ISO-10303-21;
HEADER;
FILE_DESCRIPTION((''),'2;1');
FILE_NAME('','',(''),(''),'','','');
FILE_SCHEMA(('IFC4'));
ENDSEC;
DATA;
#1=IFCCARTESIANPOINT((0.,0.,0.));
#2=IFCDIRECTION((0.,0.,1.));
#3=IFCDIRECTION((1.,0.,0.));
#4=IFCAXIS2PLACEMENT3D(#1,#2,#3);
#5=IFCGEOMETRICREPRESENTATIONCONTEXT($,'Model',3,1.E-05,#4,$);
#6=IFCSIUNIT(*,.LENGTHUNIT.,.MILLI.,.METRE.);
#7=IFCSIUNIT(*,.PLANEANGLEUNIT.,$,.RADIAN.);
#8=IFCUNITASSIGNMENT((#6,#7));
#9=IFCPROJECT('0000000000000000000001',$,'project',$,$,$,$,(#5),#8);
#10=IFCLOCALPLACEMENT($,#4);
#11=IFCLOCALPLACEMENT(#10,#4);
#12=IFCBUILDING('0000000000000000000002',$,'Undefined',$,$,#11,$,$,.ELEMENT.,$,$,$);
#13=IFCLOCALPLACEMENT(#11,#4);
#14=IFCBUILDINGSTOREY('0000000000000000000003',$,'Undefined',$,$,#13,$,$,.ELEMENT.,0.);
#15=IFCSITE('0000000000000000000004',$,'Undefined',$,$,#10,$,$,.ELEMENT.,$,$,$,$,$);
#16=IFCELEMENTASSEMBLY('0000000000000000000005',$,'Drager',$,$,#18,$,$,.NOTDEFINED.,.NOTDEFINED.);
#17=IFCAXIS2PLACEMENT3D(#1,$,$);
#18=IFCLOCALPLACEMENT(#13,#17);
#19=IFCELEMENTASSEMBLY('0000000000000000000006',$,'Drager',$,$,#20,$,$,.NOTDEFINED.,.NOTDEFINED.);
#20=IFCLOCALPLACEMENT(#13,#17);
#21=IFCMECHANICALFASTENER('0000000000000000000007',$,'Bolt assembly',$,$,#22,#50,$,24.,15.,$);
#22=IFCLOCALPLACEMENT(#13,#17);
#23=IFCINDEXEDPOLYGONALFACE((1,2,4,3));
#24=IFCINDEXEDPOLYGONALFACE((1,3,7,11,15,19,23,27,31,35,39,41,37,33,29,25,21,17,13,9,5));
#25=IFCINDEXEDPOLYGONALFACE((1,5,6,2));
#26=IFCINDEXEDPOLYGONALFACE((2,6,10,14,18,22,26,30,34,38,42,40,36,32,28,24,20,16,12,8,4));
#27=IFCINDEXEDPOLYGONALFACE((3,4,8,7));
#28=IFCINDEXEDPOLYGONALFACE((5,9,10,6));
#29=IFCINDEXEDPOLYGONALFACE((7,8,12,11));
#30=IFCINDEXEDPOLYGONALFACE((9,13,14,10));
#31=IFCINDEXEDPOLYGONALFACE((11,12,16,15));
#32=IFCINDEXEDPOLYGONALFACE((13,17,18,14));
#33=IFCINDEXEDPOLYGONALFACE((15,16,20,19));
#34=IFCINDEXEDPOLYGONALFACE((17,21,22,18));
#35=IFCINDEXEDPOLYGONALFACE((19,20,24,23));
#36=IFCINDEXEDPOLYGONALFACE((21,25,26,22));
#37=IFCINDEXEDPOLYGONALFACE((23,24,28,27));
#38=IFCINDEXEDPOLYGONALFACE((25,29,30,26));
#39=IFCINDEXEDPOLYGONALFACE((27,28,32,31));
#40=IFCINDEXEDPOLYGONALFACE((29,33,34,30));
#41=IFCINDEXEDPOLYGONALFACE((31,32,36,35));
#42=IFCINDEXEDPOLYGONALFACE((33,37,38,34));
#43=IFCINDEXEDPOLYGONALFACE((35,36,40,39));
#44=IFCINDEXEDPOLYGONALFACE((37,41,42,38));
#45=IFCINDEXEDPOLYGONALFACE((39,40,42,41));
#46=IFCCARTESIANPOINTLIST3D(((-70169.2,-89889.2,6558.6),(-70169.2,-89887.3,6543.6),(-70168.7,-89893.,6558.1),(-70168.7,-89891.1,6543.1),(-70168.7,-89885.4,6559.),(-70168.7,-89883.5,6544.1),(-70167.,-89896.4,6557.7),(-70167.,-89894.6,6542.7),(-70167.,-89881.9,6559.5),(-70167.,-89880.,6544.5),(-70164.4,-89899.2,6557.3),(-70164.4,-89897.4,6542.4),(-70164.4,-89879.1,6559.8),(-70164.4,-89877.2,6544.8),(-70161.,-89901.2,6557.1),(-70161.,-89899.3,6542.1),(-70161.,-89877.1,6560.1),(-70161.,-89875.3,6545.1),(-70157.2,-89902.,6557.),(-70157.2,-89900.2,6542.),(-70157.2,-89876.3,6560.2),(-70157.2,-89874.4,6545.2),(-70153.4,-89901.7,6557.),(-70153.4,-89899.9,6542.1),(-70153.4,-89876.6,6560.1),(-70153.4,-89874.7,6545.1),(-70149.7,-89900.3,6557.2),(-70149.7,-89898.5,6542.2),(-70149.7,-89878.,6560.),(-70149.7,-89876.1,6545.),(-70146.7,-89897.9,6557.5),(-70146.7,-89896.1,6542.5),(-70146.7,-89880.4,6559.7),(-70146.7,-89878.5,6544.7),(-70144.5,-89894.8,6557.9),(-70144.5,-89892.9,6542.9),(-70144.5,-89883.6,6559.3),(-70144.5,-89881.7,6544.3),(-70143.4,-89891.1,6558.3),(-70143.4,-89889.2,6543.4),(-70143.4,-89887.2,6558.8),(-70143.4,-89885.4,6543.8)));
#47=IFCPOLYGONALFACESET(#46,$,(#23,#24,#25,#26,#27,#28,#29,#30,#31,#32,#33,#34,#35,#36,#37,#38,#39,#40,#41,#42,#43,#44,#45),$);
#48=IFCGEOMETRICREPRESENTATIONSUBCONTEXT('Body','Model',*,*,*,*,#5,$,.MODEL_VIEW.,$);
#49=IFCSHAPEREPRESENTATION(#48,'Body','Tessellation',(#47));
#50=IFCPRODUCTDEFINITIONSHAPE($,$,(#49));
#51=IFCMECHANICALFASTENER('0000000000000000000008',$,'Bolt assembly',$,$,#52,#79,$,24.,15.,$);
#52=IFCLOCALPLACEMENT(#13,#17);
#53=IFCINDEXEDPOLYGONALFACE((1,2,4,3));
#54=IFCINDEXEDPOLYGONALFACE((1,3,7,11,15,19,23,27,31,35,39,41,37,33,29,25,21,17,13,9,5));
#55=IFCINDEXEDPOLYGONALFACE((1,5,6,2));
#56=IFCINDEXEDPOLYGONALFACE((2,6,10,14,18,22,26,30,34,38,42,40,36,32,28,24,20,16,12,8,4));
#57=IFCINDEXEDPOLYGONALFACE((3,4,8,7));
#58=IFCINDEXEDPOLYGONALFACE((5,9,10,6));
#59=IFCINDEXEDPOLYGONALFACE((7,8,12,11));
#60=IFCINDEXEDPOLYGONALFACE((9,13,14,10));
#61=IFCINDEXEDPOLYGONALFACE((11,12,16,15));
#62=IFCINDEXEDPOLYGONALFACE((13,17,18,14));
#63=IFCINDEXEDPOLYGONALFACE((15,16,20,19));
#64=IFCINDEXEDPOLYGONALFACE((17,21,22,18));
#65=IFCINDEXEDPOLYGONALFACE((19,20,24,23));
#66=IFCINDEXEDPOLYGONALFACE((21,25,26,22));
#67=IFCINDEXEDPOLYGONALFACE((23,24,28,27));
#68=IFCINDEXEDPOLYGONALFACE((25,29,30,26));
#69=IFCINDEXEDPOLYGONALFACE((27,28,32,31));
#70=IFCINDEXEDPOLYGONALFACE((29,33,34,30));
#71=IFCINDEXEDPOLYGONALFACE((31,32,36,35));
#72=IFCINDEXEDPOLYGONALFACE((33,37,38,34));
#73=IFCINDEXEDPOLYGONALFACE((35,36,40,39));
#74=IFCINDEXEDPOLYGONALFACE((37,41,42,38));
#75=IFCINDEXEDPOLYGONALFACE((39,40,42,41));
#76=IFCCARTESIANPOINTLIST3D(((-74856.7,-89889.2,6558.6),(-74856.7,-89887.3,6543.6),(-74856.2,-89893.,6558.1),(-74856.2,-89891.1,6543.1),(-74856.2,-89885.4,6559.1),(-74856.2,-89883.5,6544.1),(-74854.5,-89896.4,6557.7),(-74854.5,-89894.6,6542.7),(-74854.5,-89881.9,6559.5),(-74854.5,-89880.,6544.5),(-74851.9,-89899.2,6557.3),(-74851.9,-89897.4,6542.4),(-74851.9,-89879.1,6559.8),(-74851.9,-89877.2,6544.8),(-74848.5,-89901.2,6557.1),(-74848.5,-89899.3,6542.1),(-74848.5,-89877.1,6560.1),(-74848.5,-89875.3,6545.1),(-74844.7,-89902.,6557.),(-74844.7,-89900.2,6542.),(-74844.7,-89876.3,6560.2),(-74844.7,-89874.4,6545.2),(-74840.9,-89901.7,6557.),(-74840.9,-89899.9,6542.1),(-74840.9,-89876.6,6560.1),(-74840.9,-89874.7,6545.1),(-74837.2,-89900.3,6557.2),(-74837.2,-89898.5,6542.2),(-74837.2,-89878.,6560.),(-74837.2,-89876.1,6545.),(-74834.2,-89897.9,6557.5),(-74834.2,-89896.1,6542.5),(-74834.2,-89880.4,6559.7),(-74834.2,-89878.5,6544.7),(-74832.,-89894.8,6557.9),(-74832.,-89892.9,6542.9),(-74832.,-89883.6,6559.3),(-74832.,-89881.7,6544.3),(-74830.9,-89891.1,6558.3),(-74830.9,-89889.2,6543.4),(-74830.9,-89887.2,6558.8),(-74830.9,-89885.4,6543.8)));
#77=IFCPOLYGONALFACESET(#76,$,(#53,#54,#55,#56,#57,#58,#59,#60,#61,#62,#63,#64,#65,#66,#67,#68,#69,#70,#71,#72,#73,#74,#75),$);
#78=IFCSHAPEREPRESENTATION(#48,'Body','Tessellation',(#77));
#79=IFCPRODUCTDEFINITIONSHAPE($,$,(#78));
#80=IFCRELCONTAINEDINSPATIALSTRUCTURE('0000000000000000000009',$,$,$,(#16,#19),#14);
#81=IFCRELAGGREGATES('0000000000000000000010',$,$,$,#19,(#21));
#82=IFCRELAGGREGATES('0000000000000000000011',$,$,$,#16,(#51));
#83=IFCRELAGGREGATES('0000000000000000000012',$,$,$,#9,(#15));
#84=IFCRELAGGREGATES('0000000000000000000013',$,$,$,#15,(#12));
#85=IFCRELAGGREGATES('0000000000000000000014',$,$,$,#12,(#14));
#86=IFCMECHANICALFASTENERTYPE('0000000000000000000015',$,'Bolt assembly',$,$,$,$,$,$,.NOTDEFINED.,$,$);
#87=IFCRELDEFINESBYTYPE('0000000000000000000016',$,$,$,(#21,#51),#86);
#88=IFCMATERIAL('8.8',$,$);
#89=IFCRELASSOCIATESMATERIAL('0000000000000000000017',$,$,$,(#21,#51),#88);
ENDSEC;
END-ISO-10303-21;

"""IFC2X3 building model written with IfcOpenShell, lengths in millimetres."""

from ifc_helpers import new_model, si_unit, frame, origin_with_axes, origin_2d_with_axis, place, context, subcontext, project, spatial, circle, extrude, source, transform, mapped, material, type_object, element, aggregate, save


model = new_model("IFC2X3")

# Units and contexts
model_context = context("Model", 3, precision=1e-05, world=origin_with_axes())
body_context = subcontext(model_context, "Body", "Model", "MODEL_VIEW")
ifc_project = project(units=[si_unit("LENGTHUNIT", "METRE", prefix="MILLI"), si_unit("PLANEANGLEUNIT", "RADIAN")], contexts=[model_context])

# Site, building, storey
site_placement = place(None, origin_with_axes())
site = spatial("IfcSite", under=ifc_project, at=site_placement, Name="Undefined", CompositionType="ELEMENT")
building_placement = place(site_placement, origin_with_axes())
building = spatial("IfcBuilding", under=site, at=building_placement, Name="Undefined", CompositionType="ELEMENT")
storey_placement = place(building_placement, origin_with_axes())
storey = spatial("IfcBuildingStorey", under=building, at=storey_placement, Name="Undefined", CompositionType="ELEMENT", Elevation=0.0)

# Element assembly
assembly_1_placement = place(storey_placement, origin_with_axes())
assembly_1 = element("IfcElementAssembly", 1, at=assembly_1_placement, inside=storey, Name="Drager", AssemblyPlace="NOTDEFINED", PredefinedType="NOTDEFINED")

# Shared definitions
ifc_material_1 = material(Name="8.8")
mechanical_fastener_type = type_object("IfcMechanicalFastenerType", Name="Bolt assembly")

# Element assembly, mechanical fastener
assembly_2_placement = place(storey_placement, origin_with_axes())
assembly_2 = element("IfcElementAssembly", 2, at=assembly_2_placement, inside=storey, Name="Drager", AssemblyPlace="NOTDEFINED", PredefinedType="NOTDEFINED")
shared_shape_1 = source(origin_with_axes(), body_context, "Body", "SweptSolid", [
    extrude(circle(Radius=13.0, at=origin_2d_with_axis()), frame((0.0, -7.5, 0.0), z_axis=(0.0, 1.0, 0.0), x_axis=(1.0, 0.0, 0.0)), (0.0, 0.0, 1.0), 15.1),
])
mechanical_fastener_1_placement = place(assembly_2_placement, frame((-70156.2, -89888.2, 6551.2), z_axis=(0.0, -0.992546, -0.121869), x_axis=(-1.0, 0.0, 0.0)))
mechanical_fastener_1 = element("IfcMechanicalFastener", 3, at=mechanical_fastener_1_placement, type_object=mechanical_fastener_type, material=ifc_material_1, Name="Bolt assembly", NominalDiameter=24.0, NominalLength=15.0, context=body_context, shape_type="MappedRepresentation", body=[
    mapped(shared_shape_1, transform((0.0, 0.0, 0.0))),
])
aggregate(assembly_2, [mechanical_fastener_1])

# Mechanical fastener
shared_shape_2 = source(origin_with_axes(), body_context, "Body", "SweptSolid", [
    extrude(circle(Radius=13.0, at=origin_2d_with_axis()), frame((0.0, -7.5, 0.0), z_axis=(0.0, 1.0, 0.0), x_axis=(1.0, 0.0, 0.0)), (0.0, 0.0, 1.0), 15.1),
])
mechanical_fastener_2_placement = place(assembly_1_placement, frame((-74843.7, -89888.2, 6551.2), z_axis=(0.0, -0.992546, -0.121869), x_axis=(-1.0, 0.0, 0.0)))
mechanical_fastener_2 = element("IfcMechanicalFastener", 4, at=mechanical_fastener_2_placement, type_object=mechanical_fastener_type, material=ifc_material_1, Name="Bolt assembly", NominalDiameter=24.0, NominalLength=15.0, context=body_context, shape_type="MappedRepresentation", body=[
    mapped(shared_shape_2, transform((0.0, 0.0, 0.0))),
])
aggregate(assembly_1, [mechanical_fastener_2])

save(model, "model.ifc")
